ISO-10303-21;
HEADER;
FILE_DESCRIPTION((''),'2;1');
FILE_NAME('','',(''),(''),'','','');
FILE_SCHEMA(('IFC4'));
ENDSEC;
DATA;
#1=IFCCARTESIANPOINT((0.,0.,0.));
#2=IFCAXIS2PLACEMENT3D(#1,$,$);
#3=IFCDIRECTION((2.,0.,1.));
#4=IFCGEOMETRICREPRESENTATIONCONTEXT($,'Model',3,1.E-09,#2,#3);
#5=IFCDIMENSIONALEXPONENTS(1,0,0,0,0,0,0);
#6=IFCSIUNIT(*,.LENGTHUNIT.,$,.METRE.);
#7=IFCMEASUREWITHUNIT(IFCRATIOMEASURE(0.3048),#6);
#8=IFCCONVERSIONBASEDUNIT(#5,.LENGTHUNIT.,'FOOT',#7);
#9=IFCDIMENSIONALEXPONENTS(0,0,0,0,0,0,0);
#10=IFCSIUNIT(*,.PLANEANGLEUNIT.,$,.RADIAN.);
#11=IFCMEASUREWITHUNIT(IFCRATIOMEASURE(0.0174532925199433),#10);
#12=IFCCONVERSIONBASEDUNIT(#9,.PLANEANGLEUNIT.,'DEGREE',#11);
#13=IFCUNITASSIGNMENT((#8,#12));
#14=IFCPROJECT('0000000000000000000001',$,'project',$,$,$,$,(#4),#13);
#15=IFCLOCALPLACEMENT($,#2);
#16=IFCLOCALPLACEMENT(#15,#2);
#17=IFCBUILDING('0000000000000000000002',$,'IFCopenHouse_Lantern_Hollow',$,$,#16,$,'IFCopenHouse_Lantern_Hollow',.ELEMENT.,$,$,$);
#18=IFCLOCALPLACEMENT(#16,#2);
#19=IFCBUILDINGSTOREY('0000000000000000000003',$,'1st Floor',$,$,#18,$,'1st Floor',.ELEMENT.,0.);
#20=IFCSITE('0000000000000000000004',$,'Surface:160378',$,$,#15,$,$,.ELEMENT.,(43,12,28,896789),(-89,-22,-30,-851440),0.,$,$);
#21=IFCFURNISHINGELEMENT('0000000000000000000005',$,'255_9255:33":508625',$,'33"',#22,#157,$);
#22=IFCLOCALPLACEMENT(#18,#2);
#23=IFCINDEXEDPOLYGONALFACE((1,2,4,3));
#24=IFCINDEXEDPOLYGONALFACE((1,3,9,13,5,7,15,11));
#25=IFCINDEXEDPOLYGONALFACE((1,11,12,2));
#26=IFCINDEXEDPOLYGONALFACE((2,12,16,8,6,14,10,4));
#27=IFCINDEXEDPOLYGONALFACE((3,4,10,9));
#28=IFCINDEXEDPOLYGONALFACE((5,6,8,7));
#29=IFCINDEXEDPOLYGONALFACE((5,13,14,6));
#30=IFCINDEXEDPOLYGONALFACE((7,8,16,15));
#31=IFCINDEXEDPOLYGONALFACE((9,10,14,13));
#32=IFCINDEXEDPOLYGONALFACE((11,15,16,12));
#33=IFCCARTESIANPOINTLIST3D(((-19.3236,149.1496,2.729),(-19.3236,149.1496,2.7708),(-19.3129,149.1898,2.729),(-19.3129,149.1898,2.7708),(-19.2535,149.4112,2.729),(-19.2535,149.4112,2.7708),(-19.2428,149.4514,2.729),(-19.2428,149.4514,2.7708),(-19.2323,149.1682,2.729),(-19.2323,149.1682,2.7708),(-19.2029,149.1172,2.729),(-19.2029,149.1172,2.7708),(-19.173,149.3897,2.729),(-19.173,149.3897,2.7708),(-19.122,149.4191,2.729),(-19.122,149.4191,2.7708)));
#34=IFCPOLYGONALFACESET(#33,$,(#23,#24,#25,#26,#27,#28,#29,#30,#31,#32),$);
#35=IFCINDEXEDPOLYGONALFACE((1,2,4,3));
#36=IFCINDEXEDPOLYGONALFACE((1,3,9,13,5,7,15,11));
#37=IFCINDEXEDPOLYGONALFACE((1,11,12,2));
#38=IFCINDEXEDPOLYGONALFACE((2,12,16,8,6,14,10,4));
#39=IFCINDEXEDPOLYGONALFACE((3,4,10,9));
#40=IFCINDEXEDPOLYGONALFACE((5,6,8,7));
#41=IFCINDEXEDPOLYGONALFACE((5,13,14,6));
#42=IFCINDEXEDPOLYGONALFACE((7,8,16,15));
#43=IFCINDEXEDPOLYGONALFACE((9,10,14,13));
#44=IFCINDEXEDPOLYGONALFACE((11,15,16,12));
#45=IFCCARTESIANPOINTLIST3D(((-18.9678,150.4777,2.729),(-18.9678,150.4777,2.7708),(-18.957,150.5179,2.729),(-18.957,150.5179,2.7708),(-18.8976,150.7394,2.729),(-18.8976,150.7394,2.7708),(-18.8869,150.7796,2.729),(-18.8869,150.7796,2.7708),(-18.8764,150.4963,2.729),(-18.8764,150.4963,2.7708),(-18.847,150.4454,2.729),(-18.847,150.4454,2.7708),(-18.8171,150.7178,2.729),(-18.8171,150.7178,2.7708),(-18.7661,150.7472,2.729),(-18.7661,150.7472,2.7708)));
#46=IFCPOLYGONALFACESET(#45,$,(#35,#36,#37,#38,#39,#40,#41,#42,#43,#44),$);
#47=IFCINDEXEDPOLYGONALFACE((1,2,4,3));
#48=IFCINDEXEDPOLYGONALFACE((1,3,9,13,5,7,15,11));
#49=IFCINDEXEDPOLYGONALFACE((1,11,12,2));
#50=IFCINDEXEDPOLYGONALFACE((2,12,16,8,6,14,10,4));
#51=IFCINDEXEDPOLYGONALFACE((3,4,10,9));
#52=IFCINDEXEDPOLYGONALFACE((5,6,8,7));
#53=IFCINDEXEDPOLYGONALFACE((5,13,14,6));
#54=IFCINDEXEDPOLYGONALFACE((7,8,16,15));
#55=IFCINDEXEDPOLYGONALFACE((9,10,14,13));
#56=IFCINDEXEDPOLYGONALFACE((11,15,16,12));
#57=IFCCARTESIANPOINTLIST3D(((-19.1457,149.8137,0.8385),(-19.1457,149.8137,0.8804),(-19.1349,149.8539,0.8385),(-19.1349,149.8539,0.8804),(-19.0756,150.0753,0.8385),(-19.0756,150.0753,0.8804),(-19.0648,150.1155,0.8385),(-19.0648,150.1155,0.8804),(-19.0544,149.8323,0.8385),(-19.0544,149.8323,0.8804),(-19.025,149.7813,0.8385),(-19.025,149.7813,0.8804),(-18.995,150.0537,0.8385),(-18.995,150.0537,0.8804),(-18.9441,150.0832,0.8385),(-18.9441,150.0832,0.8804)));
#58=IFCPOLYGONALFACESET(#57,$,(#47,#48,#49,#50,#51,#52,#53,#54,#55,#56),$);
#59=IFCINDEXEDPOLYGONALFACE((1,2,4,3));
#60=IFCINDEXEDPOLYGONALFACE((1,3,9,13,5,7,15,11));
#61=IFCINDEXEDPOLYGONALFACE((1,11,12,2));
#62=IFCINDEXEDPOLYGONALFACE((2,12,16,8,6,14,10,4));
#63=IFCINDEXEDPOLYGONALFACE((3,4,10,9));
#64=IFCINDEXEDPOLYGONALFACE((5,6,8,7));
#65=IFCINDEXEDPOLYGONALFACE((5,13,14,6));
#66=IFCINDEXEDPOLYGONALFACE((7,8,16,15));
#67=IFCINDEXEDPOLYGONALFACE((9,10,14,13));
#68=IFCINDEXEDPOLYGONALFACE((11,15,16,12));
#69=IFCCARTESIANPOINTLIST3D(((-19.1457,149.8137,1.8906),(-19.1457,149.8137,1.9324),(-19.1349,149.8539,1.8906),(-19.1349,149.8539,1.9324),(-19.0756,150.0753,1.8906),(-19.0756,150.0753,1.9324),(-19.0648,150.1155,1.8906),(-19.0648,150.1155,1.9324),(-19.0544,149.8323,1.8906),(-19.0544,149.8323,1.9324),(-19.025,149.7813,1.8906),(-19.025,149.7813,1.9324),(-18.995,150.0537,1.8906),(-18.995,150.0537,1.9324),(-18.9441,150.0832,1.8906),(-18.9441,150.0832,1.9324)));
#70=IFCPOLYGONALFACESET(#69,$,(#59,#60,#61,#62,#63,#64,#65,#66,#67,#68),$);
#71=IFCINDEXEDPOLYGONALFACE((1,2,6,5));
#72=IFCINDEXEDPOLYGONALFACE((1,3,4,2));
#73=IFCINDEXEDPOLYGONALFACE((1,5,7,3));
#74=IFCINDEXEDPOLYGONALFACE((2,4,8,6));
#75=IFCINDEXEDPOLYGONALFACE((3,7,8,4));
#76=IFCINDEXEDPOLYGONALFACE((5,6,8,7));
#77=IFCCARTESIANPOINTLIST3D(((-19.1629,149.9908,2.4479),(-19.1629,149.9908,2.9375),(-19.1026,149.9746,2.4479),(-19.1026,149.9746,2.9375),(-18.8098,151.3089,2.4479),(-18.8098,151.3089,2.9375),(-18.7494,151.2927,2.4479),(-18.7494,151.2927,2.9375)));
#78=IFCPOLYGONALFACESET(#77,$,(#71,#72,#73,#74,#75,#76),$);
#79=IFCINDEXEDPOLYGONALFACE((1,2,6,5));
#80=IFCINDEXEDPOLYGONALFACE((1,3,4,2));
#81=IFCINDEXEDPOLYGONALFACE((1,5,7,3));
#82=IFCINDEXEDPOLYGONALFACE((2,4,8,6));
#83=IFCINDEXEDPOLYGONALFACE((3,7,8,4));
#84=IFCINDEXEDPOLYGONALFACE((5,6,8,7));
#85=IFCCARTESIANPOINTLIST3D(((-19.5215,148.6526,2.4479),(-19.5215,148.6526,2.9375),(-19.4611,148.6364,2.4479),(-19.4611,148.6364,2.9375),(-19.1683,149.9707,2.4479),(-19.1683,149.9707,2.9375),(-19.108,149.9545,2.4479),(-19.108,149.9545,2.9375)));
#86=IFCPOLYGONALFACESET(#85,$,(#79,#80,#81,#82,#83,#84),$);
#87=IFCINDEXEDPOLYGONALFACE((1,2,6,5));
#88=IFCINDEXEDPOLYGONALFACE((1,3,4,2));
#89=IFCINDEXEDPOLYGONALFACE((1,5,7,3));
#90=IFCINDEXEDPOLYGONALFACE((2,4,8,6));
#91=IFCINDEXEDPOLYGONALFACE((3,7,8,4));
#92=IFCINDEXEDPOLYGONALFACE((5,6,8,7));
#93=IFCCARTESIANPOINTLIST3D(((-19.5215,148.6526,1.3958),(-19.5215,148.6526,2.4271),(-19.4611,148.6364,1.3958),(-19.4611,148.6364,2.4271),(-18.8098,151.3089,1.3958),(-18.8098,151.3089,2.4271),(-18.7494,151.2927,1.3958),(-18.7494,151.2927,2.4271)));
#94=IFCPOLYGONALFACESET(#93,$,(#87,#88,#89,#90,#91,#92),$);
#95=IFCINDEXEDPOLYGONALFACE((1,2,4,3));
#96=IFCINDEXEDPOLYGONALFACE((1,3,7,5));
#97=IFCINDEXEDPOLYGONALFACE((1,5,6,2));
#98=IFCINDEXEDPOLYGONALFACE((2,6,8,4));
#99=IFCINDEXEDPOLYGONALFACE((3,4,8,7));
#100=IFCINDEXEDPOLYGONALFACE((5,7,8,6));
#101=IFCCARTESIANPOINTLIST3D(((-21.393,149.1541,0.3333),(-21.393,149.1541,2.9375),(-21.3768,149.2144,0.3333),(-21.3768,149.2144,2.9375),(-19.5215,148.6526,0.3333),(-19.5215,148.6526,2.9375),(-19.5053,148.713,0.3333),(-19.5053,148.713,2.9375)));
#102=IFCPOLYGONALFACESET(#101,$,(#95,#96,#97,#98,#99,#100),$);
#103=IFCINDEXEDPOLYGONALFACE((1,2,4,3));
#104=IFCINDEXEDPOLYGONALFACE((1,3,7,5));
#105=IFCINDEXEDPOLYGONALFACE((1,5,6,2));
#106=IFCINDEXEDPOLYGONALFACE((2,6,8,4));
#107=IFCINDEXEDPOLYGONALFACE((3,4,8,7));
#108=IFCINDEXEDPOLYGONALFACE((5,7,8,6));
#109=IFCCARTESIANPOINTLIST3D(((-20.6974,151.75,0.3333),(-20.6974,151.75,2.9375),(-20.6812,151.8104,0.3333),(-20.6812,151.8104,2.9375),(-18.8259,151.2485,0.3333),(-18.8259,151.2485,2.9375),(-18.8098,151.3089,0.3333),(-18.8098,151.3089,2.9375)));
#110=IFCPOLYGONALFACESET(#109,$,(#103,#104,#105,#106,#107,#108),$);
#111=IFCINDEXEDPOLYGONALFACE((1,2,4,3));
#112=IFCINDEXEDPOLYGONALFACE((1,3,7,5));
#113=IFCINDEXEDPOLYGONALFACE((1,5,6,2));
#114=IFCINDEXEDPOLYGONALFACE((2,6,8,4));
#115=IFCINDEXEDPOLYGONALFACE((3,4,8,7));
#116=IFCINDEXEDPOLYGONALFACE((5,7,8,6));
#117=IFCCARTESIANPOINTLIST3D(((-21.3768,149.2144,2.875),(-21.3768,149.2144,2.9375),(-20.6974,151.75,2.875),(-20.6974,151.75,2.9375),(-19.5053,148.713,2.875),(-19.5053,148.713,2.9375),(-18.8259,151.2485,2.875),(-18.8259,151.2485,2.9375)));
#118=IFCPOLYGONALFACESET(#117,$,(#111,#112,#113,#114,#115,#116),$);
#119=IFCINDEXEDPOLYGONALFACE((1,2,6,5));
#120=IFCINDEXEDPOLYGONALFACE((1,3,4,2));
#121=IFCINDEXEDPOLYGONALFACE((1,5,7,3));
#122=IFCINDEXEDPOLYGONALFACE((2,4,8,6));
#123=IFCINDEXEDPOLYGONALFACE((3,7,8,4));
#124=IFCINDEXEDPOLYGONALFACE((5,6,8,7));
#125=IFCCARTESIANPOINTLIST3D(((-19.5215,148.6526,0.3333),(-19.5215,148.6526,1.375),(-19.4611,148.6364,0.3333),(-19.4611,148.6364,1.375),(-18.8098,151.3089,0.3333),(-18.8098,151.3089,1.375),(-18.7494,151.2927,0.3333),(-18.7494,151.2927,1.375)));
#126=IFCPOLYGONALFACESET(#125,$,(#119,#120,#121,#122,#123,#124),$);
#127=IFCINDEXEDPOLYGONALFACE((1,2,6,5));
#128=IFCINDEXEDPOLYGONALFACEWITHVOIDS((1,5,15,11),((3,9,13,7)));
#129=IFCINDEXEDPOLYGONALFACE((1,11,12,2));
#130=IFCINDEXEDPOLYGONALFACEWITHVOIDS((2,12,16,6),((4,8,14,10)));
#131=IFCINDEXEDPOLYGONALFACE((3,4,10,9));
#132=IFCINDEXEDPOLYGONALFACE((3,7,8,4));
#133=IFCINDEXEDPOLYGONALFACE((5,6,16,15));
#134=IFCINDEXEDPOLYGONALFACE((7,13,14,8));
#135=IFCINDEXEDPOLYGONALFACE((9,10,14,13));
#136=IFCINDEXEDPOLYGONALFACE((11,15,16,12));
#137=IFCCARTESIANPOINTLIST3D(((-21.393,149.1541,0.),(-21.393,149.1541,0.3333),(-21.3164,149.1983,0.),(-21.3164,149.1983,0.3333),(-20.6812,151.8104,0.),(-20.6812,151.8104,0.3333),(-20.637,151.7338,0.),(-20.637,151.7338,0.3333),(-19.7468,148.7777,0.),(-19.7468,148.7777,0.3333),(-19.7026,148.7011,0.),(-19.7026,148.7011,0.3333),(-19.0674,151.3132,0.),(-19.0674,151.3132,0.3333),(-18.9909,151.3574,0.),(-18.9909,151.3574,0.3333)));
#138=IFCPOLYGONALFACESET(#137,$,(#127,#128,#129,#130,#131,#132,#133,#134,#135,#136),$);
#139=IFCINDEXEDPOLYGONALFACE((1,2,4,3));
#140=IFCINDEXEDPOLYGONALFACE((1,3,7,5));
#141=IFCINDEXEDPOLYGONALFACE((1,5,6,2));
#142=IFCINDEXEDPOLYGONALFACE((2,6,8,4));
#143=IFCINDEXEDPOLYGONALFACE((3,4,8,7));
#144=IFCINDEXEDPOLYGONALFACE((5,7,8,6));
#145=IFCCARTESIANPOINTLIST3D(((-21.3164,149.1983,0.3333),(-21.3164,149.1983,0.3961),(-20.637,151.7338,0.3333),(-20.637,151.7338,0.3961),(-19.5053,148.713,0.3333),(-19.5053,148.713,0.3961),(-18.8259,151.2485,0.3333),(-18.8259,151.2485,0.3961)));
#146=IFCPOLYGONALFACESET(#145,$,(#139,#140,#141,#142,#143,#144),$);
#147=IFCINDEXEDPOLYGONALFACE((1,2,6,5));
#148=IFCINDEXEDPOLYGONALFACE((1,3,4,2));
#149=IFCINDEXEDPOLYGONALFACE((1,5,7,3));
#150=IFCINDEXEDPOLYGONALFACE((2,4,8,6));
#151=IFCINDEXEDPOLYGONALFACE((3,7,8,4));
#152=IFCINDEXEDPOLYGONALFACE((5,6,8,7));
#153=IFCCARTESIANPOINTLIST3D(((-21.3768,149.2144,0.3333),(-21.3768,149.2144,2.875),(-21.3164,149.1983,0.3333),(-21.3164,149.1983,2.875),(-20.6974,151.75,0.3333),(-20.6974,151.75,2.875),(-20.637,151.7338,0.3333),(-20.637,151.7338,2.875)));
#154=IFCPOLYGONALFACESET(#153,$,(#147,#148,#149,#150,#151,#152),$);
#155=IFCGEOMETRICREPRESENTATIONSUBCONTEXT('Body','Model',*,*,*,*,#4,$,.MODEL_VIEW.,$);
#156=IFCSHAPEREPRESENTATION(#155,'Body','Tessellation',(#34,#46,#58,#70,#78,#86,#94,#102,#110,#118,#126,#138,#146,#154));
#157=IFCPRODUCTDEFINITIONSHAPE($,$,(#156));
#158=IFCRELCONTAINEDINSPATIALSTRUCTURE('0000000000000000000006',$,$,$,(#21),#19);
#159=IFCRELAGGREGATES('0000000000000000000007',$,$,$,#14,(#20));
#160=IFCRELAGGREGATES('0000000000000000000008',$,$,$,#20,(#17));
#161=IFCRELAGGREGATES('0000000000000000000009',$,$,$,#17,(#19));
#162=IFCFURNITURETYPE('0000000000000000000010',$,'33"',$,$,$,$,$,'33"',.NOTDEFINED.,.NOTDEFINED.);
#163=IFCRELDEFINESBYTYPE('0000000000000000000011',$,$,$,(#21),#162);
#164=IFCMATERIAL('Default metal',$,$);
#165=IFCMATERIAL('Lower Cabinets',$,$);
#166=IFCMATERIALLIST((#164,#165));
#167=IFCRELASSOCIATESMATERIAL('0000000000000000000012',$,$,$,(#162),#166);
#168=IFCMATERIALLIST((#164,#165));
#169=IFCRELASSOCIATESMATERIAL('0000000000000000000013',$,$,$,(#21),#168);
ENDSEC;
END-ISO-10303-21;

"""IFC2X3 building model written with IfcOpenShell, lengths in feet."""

from ifc_helpers import new_model, entity, si_unit, converted_unit, direction, frame, frame_2d, origin, origin_2d_with_axis, place, context, subcontext, project, spatial, polyline, rectangle, outline, extrude, source, transform, mapped, material, material_list, type_object, type_shapes, element, save


model = new_model("IFC2X3")

# Units and contexts
model_context = context("Model", 3, precision=1e-09, world=origin(), true_north=direction((2.0, 0.0, 1.0)))
body_context = subcontext(model_context, "Body", "Model", "MODEL_VIEW")
ifc_project = project(units=[converted_unit("LENGTHUNIT", "FOOT", entity("IfcRatioMeasure", 0.3048), si_unit("LENGTHUNIT", "METRE"), dimensions=[1, 0, 0, 0, 0, 0, 0]), converted_unit("PLANEANGLEUNIT", "DEGREE", entity("IfcRatioMeasure", 0.0174532925199433), si_unit("PLANEANGLEUNIT", "RADIAN"), dimensions=[0, 0, 0, 0, 0, 0, 0])], contexts=[model_context])

# Site, building, storey
site_placement = place(None, origin())
site = spatial("IfcSite", under=ifc_project, at=site_placement, Name="Surface:160378", CompositionType="ELEMENT", RefLatitude=(43, 12, 28, 896789), RefLongitude=(-89, -22, -30, -851440), RefElevation=0.0)
building_placement = place(site_placement, origin())
building = spatial("IfcBuilding", under=site, at=building_placement, Name="IFCopenHouse_Lantern_Hollow", LongName="IFCopenHouse_Lantern_Hollow", CompositionType="ELEMENT")
storey_placement = place(building_placement, origin())
storey = spatial("IfcBuildingStorey", under=building, at=storey_placement, Name="1st Floor", LongName="1st Floor", CompositionType="ELEMENT", Elevation=0.0)

# Furnishing element
ifc_material_1 = material(Name="Default metal")
ifc_material_2 = material(Name="Lower Cabinets")
ifc_material_list_1 = material_list([ifc_material_1, ifc_material_2])
furniture_type_1 = type_object("IfcFurnitureType", Name="33\"", ElementType="33\"", AssemblyPlace="NOTDEFINED", material=ifc_material_list_1)
shared_shape_1 = source(origin(), body_context, "Body", "SweptSolid", [
    extrude(outline(polyline([(-0.0521, -0.1562), (0.0729, -0.1562), (0.0729, 0.1562), (-0.0521, 0.1562), (-0.0521, 0.1146), (0.0313, 0.1146), (0.0313, -0.1146), (-0.0521, -0.1146), (-0.0521, -0.1562)])), frame((-0.626, -2.0521, 2.729), z_axis=(0.0, 0.0, 1.0), x_axis=(0.0, -1.0, 0.0)), (0.0, 0.0, 1.0), 0.0418),
    extrude(outline(polyline([(-0.0521, -0.1562), (0.0729, -0.1562), (0.0729, 0.1562), (-0.0521, 0.1562), (-0.0521, 0.1146), (0.0313, 0.1146), (0.0313, -0.1146), (-0.0521, -0.1146), (-0.0521, -0.1562)])), frame((0.749, -2.0521, 2.729), z_axis=(0.0, 0.0, 1.0), x_axis=(0.0, -1.0, 0.0)), (0.0, 0.0, 1.0), 0.0418),
    extrude(outline(polyline([(-0.0521, -0.1562), (0.0729, -0.1562), (0.0729, 0.1562), (-0.0521, 0.1562), (-0.0521, 0.1146), (0.0313, 0.1146), (0.0313, -0.1146), (-0.0521, -0.1146), (-0.0521, -0.1562)])), frame((0.0615, -2.0521, 0.8385), z_axis=(0.0, 0.0, 1.0), x_axis=(0.0, -1.0, 0.0)), (0.0, 0.0, 1.0), 0.0418),
    extrude(outline(polyline([(-0.0521, -0.1562), (0.0729, -0.1562), (0.0729, 0.1562), (-0.0521, 0.1562), (-0.0521, 0.1146), (0.0313, 0.1146), (0.0313, -0.1146), (-0.0521, -0.1146), (-0.0521, -0.1562)])), frame((0.0615, -2.0521, 1.8906), z_axis=(0.0, 0.0, 1.0), x_axis=(0.0, -1.0, 0.0)), (0.0, 0.0, 1.0), 0.0418),
    extrude(rectangle(XDim=0.0625, YDim=1.3646, at=frame_2d((0.0, 0.0), x_axis=(1.0, 0.0))), frame((0.7542, -1.9688, 2.4479), z_axis=(0.0, 0.0, 1.0), x_axis=(0.0, 1.0, 0.0)), (0.0, 0.0, 1.0), 0.4896),
    extrude(rectangle(XDim=0.0625, YDim=1.3646, at=origin_2d_with_axis()), frame((-0.6312, -1.9688, 2.4479), z_axis=(0.0, 0.0, 1.0), x_axis=(0.0, 1.0, 0.0)), (0.0, 0.0, 1.0), 0.4896),
    extrude(rectangle(XDim=0.0625, YDim=2.75, at=frame_2d((0.0, 0.0), x_axis=(1.0, 0.0))), frame((0.0615, -1.9688, 1.3958), z_axis=(0.0, 0.0, 1.0), x_axis=(0.0, 1.0, 0.0)), (0.0, 0.0, 1.0), 1.0313),
    extrude(rectangle(XDim=0.0625, YDim=1.9375, at=frame_2d((0.0, 0.0), x_axis=(1.0, 0.0))), frame((-1.2823, -0.9687, 0.3333)), (0.0, 0.0, 1.0), 2.6042),
    extrude(rectangle(XDim=0.0625, YDim=1.9375, at=frame_2d((0.0, 0.0), x_axis=(1.0, 0.0))), frame((1.4052, -0.9687, 0.3333)), (0.0, 0.0, 1.0), 2.6042),
    extrude(rectangle(XDim=2.625, YDim=1.9375, at=origin_2d_with_axis()), frame((0.0615, -0.9688, 2.875), z_axis=(0.0, 0.0, 1.0), x_axis=(-1.0, 0.0, 0.0)), (0.0, 0.0, 1.0), 0.0625),
    extrude(rectangle(XDim=0.0625, YDim=2.75, at=frame_2d((0.0, 0.0), x_axis=(1.0, 0.0))), frame((0.0615, -1.9688, 0.3333), z_axis=(0.0, 0.0, 1.0), x_axis=(0.0, 1.0, 0.0)), (0.0, 0.0, 1.0), 1.0417),
    extrude(outline(polyline([(-1.375, -0.875), (1.375, -0.875), (1.375, 0.875), (-1.375, 0.875), (-1.375, -0.875)]), holes=[polyline([(-1.3125, -0.8125), (-1.3125, 0.8125), (1.3125, 0.8125), (1.3125, -0.8125), (-1.3125, -0.8125)])]), frame((0.0615, -0.875, 0.0)), (0.0, 0.0, 1.0), 0.3333),
    extrude(rectangle(XDim=2.625, YDim=1.875, at=frame_2d((0.0, 0.0), x_axis=(1.0, 0.0))), frame((0.0615, -1.0, 0.3333), z_axis=(0.0, 0.0, 1.0), x_axis=(-1.0, 0.0, 0.0)), (0.0, 0.0, 1.0), 0.0627),
    extrude(rectangle(XDim=0.0625, YDim=2.625, at=origin_2d_with_axis()), frame((0.0615, -0.0312, 0.3333), z_axis=(0.0, 0.0, 1.0), x_axis=(0.0, 1.0, 0.0)), (0.0, 0.0, 1.0), 2.5417),
])
type_shapes(furniture_type_1, [shared_shape_1])
ifc_material_list_2 = material_list([ifc_material_1, ifc_material_2])
furnishing_1_placement = place(storey_placement, frame((-21.053, 150.4228, 0.0), z_axis=(0.0, 0.0, 1.0), x_axis=(0.258819, 0.965926, 0.0)))
element("IfcFurnishingElement", 1, at=furnishing_1_placement, inside=storey, type_object=furniture_type_1, material=ifc_material_list_2, Name="255_9255:33\":508625", ObjectType="33\"", context=body_context, shape_type="MappedRepresentation", body=[
    mapped(shared_shape_1, transform((0.0, 0.0, 0.0), scale=1.0)),
])

save(model, "model.ifc")
